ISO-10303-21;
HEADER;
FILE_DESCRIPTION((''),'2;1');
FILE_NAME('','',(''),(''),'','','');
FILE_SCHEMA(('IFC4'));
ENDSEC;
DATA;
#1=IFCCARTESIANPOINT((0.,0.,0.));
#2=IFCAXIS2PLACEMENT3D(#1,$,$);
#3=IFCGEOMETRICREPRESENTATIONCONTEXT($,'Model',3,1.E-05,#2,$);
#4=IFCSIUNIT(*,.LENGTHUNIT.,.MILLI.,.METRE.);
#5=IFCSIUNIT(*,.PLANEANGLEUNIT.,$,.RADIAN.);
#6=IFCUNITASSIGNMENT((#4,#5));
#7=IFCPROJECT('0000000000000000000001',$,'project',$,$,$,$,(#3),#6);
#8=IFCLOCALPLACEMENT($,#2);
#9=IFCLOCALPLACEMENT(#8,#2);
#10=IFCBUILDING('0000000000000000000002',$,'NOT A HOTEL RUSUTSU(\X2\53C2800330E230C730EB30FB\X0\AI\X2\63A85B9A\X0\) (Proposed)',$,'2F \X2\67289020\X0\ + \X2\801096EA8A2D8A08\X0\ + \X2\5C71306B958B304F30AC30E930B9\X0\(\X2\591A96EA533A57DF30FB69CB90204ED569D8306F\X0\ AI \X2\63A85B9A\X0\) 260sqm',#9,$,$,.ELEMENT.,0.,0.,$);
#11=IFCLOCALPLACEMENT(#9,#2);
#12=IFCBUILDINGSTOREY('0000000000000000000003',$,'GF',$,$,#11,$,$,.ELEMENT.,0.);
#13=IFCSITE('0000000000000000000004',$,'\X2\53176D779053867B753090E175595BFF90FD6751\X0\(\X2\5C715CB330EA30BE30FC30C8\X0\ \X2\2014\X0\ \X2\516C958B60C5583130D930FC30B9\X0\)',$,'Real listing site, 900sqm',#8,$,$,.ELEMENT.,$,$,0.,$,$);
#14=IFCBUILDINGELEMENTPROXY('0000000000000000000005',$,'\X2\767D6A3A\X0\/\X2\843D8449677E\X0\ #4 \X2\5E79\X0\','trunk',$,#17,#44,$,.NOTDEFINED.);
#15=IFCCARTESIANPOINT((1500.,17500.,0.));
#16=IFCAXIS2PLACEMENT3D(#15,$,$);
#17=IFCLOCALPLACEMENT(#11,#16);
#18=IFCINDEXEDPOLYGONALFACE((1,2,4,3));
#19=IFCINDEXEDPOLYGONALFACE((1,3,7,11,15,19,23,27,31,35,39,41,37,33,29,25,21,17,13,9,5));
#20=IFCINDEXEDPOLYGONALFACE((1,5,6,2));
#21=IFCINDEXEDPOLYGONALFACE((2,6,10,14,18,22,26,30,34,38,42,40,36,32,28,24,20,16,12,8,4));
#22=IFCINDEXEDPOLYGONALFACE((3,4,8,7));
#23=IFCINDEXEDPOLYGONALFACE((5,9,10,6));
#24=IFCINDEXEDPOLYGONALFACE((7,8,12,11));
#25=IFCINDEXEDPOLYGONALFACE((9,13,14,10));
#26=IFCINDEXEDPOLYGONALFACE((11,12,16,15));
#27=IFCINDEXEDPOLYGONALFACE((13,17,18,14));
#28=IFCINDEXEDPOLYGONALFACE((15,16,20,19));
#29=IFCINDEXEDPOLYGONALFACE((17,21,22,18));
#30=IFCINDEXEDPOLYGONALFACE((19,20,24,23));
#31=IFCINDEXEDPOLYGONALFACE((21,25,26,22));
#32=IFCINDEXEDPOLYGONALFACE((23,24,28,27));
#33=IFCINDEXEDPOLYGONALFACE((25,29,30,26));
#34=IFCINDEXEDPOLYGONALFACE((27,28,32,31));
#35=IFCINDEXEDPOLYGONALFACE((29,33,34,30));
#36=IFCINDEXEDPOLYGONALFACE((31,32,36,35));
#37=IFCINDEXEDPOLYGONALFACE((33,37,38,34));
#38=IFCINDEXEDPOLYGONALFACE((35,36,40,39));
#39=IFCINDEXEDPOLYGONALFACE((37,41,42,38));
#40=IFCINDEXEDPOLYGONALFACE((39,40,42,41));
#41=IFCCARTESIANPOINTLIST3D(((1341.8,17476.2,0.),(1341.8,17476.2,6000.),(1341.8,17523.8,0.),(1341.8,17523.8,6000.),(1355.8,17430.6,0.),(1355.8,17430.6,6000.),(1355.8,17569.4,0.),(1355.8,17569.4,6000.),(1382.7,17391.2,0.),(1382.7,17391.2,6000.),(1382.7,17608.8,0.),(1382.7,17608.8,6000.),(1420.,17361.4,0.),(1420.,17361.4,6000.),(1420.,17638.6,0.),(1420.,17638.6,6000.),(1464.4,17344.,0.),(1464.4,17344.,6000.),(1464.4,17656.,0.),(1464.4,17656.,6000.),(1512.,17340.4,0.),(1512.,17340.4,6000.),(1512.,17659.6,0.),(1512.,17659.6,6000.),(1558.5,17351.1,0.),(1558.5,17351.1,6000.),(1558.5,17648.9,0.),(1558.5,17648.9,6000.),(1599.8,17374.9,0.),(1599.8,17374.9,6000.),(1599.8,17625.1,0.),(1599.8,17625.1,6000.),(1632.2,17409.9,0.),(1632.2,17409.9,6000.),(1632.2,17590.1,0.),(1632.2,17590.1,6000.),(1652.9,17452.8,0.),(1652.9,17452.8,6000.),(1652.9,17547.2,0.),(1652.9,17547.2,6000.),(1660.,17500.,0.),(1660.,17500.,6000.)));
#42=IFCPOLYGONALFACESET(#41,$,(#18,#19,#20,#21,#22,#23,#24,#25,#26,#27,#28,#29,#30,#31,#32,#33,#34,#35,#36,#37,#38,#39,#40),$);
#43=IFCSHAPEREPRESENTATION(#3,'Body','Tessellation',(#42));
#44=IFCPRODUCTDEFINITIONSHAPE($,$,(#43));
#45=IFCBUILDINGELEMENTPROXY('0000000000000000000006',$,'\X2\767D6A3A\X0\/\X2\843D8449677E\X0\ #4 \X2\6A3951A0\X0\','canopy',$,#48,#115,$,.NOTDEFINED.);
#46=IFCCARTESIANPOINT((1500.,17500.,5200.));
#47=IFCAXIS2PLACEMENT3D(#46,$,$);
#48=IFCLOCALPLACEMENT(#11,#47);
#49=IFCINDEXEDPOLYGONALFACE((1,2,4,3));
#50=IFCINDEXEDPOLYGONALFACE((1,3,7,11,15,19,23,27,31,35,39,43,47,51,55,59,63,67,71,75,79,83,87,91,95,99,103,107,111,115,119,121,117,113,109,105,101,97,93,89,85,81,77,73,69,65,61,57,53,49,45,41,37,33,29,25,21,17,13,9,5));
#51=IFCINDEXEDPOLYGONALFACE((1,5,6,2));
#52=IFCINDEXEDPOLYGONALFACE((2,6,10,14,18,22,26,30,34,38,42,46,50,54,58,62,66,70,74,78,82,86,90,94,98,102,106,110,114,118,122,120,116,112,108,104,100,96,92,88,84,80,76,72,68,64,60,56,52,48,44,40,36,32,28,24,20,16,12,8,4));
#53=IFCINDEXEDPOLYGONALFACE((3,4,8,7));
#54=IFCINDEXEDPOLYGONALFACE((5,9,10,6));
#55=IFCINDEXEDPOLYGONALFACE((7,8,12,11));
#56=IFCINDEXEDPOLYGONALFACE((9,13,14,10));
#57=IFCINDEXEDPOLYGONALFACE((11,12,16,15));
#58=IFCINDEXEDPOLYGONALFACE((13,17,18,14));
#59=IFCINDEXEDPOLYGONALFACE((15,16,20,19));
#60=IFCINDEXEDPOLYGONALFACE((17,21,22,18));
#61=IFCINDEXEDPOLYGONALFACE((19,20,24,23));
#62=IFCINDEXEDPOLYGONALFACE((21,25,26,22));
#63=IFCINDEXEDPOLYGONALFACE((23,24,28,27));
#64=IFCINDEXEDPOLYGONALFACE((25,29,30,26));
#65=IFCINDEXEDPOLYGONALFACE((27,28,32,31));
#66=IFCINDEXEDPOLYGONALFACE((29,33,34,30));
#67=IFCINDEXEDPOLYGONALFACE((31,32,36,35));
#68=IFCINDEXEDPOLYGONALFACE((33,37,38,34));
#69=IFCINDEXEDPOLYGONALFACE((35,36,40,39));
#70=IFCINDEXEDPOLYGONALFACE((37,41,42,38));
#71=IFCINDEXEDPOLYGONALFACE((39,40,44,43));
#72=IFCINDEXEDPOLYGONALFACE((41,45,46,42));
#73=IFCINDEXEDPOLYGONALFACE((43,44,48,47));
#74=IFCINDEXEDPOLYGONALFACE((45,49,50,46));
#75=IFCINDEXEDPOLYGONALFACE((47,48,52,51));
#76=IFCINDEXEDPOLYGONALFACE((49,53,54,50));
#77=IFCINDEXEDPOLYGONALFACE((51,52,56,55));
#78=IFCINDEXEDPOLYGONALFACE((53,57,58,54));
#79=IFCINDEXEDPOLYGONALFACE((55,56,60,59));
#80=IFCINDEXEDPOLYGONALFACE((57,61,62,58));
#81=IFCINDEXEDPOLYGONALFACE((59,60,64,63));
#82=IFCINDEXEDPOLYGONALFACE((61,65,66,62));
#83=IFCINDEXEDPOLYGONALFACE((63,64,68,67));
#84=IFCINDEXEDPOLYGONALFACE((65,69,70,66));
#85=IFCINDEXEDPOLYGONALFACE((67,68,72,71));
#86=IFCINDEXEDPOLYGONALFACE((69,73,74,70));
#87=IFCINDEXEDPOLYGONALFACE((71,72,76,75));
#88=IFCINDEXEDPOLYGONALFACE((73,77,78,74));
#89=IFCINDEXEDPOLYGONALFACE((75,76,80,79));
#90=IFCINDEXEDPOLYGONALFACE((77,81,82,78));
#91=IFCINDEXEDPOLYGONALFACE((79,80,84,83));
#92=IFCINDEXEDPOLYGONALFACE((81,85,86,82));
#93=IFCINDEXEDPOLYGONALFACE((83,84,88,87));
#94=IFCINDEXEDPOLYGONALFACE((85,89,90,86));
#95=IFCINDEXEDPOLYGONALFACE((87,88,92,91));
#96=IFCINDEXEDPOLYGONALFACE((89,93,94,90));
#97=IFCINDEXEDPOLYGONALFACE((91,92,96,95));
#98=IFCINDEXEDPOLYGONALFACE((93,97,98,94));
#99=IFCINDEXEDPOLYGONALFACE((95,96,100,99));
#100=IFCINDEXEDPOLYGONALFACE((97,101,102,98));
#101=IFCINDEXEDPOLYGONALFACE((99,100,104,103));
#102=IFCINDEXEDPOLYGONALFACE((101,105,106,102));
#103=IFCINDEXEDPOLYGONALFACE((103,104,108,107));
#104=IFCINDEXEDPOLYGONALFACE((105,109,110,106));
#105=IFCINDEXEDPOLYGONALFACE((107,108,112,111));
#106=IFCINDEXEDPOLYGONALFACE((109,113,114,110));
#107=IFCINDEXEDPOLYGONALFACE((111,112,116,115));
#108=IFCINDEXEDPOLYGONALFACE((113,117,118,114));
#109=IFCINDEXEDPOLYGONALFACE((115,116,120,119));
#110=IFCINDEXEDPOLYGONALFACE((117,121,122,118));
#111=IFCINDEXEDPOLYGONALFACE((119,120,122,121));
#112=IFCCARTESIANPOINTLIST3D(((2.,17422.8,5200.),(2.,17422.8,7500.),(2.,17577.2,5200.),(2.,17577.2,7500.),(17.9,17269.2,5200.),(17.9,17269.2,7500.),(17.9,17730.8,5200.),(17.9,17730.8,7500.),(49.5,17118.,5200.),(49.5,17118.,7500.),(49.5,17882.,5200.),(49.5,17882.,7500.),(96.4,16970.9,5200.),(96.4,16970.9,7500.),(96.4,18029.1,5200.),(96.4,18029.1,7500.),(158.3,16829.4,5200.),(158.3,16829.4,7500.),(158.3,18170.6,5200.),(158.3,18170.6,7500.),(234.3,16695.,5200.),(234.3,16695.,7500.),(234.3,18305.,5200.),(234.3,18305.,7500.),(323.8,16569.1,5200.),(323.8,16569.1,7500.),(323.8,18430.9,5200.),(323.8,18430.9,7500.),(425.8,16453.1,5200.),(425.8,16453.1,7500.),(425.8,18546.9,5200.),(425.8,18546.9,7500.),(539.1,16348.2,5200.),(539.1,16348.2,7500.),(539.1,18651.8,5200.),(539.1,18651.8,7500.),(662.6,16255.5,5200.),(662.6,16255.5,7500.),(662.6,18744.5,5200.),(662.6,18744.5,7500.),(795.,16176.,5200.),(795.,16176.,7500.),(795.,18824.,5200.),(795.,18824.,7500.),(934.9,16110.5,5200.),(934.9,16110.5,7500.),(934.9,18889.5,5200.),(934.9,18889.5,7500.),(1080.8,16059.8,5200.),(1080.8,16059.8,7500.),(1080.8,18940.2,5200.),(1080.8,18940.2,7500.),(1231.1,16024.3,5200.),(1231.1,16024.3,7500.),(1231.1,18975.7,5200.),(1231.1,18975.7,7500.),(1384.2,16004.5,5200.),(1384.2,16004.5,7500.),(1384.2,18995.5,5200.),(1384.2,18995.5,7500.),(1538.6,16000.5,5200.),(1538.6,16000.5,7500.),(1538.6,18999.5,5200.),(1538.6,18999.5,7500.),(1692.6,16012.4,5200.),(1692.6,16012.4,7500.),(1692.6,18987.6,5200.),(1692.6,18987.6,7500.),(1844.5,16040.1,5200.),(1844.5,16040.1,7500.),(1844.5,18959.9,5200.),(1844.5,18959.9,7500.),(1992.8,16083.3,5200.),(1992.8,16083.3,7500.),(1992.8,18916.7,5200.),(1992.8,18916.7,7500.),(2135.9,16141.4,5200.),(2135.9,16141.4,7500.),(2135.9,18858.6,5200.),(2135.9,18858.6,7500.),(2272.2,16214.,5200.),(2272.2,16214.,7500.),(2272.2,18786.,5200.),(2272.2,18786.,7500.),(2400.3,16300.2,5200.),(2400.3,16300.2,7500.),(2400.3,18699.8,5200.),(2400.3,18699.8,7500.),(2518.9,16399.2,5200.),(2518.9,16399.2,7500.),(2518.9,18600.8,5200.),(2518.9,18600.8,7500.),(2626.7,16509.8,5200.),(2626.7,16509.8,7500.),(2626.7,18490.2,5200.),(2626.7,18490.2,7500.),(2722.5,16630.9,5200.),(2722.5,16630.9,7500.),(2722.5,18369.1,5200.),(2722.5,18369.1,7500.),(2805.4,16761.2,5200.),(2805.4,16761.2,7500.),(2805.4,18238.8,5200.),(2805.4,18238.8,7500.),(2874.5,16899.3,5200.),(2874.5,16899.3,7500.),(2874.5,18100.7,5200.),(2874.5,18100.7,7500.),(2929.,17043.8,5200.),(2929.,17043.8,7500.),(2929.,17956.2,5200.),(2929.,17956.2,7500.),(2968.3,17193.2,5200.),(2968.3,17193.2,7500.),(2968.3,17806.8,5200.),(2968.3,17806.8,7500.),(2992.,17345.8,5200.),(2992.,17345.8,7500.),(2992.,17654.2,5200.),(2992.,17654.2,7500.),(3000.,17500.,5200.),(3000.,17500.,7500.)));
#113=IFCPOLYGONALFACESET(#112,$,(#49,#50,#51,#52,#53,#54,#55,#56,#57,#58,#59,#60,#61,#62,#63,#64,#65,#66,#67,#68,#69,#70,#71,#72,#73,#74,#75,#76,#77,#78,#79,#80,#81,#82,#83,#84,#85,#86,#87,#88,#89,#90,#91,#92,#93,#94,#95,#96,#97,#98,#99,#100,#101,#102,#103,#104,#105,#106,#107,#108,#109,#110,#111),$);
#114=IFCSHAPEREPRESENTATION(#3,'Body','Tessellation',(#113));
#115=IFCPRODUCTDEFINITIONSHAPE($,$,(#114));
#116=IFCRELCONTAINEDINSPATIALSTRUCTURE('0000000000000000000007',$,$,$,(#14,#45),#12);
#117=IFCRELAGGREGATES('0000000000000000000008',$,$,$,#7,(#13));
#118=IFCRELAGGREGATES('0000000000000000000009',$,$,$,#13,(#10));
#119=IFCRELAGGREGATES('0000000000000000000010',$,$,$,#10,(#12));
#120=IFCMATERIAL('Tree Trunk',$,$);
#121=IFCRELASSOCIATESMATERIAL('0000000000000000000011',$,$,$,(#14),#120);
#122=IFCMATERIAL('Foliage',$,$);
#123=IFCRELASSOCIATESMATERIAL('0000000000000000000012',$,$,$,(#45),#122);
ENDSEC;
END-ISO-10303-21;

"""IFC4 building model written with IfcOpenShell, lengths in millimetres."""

from ifc_helpers import new_model, si_unit, frame, origin, origin_2d, place, context, project, spatial, circle, extrude, material, element, save


model = new_model("IFC4")

# Units and contexts
model_context = context("Model", 3, precision=1e-05, world=origin())
ifc_project = project(units=[si_unit("LENGTHUNIT", "METRE", prefix="MILLI"), si_unit("PLANEANGLEUNIT", "RADIAN")], contexts=[model_context])

# Site, building, storey
site_placement = place(None, origin())
site = spatial("IfcSite", under=ifc_project, at=site_placement, Name="北海道虻田郡留寿都村(山岳リゾート — 公開情報ベース)", ObjectType="Real listing site, 900sqm", CompositionType="ELEMENT", RefElevation=0.0)
building_placement = place(site_placement, origin())
building = spatial("IfcBuilding", under=site, at=building_placement, Name="NOT A HOTEL RUSUTSU(参考モデル・AI推定) (Proposed)", ObjectType="2F 木造 + 耐雪設計 + 山に開くガラス(多雪区域・構造仕様は AI 推定) 260sqm", CompositionType="ELEMENT", ElevationOfRefHeight=0.0, ElevationOfTerrain=0.0)
storey_placement = place(building_placement, origin())
storey = spatial("IfcBuildingStorey", under=building, at=storey_placement, Name="GF", CompositionType="ELEMENT", Elevation=0.0)

# Building element proxies
ifc_material_1 = material(Name="Tree Trunk")
ifc_material_2 = material(Name="Foliage")
proxy_1_placement = place(storey_placement, frame((1500.0, 17500.0, 0.0)))
element("IfcBuildingElementProxy", 1, at=proxy_1_placement, inside=storey, material=ifc_material_1, Name="白樺/落葉松 #4 幹", Description="trunk", PredefinedType="NOTDEFINED", context=model_context, shape_type="SweptSolid", body=[
    extrude(circle(Radius=160.0, at=origin_2d()), frame((1500.0, 17500.0, 0.0)), (0.0, 0.0, 1.0), 6000.0),
])
proxy_2_placement = place(storey_placement, frame((1500.0, 17500.0, 5200.0)))
element("IfcBuildingElementProxy", 2, at=proxy_2_placement, inside=storey, material=ifc_material_2, Name="白樺/落葉松 #4 樹冠", Description="canopy", PredefinedType="NOTDEFINED", context=model_context, shape_type="SweptSolid", body=[
    extrude(circle(Radius=1500.0, at=origin_2d()), frame((1500.0, 17500.0, 5200.0)), (0.0, 0.0, 1.0), 2300.0),
])

save(model, "model.ifc")
